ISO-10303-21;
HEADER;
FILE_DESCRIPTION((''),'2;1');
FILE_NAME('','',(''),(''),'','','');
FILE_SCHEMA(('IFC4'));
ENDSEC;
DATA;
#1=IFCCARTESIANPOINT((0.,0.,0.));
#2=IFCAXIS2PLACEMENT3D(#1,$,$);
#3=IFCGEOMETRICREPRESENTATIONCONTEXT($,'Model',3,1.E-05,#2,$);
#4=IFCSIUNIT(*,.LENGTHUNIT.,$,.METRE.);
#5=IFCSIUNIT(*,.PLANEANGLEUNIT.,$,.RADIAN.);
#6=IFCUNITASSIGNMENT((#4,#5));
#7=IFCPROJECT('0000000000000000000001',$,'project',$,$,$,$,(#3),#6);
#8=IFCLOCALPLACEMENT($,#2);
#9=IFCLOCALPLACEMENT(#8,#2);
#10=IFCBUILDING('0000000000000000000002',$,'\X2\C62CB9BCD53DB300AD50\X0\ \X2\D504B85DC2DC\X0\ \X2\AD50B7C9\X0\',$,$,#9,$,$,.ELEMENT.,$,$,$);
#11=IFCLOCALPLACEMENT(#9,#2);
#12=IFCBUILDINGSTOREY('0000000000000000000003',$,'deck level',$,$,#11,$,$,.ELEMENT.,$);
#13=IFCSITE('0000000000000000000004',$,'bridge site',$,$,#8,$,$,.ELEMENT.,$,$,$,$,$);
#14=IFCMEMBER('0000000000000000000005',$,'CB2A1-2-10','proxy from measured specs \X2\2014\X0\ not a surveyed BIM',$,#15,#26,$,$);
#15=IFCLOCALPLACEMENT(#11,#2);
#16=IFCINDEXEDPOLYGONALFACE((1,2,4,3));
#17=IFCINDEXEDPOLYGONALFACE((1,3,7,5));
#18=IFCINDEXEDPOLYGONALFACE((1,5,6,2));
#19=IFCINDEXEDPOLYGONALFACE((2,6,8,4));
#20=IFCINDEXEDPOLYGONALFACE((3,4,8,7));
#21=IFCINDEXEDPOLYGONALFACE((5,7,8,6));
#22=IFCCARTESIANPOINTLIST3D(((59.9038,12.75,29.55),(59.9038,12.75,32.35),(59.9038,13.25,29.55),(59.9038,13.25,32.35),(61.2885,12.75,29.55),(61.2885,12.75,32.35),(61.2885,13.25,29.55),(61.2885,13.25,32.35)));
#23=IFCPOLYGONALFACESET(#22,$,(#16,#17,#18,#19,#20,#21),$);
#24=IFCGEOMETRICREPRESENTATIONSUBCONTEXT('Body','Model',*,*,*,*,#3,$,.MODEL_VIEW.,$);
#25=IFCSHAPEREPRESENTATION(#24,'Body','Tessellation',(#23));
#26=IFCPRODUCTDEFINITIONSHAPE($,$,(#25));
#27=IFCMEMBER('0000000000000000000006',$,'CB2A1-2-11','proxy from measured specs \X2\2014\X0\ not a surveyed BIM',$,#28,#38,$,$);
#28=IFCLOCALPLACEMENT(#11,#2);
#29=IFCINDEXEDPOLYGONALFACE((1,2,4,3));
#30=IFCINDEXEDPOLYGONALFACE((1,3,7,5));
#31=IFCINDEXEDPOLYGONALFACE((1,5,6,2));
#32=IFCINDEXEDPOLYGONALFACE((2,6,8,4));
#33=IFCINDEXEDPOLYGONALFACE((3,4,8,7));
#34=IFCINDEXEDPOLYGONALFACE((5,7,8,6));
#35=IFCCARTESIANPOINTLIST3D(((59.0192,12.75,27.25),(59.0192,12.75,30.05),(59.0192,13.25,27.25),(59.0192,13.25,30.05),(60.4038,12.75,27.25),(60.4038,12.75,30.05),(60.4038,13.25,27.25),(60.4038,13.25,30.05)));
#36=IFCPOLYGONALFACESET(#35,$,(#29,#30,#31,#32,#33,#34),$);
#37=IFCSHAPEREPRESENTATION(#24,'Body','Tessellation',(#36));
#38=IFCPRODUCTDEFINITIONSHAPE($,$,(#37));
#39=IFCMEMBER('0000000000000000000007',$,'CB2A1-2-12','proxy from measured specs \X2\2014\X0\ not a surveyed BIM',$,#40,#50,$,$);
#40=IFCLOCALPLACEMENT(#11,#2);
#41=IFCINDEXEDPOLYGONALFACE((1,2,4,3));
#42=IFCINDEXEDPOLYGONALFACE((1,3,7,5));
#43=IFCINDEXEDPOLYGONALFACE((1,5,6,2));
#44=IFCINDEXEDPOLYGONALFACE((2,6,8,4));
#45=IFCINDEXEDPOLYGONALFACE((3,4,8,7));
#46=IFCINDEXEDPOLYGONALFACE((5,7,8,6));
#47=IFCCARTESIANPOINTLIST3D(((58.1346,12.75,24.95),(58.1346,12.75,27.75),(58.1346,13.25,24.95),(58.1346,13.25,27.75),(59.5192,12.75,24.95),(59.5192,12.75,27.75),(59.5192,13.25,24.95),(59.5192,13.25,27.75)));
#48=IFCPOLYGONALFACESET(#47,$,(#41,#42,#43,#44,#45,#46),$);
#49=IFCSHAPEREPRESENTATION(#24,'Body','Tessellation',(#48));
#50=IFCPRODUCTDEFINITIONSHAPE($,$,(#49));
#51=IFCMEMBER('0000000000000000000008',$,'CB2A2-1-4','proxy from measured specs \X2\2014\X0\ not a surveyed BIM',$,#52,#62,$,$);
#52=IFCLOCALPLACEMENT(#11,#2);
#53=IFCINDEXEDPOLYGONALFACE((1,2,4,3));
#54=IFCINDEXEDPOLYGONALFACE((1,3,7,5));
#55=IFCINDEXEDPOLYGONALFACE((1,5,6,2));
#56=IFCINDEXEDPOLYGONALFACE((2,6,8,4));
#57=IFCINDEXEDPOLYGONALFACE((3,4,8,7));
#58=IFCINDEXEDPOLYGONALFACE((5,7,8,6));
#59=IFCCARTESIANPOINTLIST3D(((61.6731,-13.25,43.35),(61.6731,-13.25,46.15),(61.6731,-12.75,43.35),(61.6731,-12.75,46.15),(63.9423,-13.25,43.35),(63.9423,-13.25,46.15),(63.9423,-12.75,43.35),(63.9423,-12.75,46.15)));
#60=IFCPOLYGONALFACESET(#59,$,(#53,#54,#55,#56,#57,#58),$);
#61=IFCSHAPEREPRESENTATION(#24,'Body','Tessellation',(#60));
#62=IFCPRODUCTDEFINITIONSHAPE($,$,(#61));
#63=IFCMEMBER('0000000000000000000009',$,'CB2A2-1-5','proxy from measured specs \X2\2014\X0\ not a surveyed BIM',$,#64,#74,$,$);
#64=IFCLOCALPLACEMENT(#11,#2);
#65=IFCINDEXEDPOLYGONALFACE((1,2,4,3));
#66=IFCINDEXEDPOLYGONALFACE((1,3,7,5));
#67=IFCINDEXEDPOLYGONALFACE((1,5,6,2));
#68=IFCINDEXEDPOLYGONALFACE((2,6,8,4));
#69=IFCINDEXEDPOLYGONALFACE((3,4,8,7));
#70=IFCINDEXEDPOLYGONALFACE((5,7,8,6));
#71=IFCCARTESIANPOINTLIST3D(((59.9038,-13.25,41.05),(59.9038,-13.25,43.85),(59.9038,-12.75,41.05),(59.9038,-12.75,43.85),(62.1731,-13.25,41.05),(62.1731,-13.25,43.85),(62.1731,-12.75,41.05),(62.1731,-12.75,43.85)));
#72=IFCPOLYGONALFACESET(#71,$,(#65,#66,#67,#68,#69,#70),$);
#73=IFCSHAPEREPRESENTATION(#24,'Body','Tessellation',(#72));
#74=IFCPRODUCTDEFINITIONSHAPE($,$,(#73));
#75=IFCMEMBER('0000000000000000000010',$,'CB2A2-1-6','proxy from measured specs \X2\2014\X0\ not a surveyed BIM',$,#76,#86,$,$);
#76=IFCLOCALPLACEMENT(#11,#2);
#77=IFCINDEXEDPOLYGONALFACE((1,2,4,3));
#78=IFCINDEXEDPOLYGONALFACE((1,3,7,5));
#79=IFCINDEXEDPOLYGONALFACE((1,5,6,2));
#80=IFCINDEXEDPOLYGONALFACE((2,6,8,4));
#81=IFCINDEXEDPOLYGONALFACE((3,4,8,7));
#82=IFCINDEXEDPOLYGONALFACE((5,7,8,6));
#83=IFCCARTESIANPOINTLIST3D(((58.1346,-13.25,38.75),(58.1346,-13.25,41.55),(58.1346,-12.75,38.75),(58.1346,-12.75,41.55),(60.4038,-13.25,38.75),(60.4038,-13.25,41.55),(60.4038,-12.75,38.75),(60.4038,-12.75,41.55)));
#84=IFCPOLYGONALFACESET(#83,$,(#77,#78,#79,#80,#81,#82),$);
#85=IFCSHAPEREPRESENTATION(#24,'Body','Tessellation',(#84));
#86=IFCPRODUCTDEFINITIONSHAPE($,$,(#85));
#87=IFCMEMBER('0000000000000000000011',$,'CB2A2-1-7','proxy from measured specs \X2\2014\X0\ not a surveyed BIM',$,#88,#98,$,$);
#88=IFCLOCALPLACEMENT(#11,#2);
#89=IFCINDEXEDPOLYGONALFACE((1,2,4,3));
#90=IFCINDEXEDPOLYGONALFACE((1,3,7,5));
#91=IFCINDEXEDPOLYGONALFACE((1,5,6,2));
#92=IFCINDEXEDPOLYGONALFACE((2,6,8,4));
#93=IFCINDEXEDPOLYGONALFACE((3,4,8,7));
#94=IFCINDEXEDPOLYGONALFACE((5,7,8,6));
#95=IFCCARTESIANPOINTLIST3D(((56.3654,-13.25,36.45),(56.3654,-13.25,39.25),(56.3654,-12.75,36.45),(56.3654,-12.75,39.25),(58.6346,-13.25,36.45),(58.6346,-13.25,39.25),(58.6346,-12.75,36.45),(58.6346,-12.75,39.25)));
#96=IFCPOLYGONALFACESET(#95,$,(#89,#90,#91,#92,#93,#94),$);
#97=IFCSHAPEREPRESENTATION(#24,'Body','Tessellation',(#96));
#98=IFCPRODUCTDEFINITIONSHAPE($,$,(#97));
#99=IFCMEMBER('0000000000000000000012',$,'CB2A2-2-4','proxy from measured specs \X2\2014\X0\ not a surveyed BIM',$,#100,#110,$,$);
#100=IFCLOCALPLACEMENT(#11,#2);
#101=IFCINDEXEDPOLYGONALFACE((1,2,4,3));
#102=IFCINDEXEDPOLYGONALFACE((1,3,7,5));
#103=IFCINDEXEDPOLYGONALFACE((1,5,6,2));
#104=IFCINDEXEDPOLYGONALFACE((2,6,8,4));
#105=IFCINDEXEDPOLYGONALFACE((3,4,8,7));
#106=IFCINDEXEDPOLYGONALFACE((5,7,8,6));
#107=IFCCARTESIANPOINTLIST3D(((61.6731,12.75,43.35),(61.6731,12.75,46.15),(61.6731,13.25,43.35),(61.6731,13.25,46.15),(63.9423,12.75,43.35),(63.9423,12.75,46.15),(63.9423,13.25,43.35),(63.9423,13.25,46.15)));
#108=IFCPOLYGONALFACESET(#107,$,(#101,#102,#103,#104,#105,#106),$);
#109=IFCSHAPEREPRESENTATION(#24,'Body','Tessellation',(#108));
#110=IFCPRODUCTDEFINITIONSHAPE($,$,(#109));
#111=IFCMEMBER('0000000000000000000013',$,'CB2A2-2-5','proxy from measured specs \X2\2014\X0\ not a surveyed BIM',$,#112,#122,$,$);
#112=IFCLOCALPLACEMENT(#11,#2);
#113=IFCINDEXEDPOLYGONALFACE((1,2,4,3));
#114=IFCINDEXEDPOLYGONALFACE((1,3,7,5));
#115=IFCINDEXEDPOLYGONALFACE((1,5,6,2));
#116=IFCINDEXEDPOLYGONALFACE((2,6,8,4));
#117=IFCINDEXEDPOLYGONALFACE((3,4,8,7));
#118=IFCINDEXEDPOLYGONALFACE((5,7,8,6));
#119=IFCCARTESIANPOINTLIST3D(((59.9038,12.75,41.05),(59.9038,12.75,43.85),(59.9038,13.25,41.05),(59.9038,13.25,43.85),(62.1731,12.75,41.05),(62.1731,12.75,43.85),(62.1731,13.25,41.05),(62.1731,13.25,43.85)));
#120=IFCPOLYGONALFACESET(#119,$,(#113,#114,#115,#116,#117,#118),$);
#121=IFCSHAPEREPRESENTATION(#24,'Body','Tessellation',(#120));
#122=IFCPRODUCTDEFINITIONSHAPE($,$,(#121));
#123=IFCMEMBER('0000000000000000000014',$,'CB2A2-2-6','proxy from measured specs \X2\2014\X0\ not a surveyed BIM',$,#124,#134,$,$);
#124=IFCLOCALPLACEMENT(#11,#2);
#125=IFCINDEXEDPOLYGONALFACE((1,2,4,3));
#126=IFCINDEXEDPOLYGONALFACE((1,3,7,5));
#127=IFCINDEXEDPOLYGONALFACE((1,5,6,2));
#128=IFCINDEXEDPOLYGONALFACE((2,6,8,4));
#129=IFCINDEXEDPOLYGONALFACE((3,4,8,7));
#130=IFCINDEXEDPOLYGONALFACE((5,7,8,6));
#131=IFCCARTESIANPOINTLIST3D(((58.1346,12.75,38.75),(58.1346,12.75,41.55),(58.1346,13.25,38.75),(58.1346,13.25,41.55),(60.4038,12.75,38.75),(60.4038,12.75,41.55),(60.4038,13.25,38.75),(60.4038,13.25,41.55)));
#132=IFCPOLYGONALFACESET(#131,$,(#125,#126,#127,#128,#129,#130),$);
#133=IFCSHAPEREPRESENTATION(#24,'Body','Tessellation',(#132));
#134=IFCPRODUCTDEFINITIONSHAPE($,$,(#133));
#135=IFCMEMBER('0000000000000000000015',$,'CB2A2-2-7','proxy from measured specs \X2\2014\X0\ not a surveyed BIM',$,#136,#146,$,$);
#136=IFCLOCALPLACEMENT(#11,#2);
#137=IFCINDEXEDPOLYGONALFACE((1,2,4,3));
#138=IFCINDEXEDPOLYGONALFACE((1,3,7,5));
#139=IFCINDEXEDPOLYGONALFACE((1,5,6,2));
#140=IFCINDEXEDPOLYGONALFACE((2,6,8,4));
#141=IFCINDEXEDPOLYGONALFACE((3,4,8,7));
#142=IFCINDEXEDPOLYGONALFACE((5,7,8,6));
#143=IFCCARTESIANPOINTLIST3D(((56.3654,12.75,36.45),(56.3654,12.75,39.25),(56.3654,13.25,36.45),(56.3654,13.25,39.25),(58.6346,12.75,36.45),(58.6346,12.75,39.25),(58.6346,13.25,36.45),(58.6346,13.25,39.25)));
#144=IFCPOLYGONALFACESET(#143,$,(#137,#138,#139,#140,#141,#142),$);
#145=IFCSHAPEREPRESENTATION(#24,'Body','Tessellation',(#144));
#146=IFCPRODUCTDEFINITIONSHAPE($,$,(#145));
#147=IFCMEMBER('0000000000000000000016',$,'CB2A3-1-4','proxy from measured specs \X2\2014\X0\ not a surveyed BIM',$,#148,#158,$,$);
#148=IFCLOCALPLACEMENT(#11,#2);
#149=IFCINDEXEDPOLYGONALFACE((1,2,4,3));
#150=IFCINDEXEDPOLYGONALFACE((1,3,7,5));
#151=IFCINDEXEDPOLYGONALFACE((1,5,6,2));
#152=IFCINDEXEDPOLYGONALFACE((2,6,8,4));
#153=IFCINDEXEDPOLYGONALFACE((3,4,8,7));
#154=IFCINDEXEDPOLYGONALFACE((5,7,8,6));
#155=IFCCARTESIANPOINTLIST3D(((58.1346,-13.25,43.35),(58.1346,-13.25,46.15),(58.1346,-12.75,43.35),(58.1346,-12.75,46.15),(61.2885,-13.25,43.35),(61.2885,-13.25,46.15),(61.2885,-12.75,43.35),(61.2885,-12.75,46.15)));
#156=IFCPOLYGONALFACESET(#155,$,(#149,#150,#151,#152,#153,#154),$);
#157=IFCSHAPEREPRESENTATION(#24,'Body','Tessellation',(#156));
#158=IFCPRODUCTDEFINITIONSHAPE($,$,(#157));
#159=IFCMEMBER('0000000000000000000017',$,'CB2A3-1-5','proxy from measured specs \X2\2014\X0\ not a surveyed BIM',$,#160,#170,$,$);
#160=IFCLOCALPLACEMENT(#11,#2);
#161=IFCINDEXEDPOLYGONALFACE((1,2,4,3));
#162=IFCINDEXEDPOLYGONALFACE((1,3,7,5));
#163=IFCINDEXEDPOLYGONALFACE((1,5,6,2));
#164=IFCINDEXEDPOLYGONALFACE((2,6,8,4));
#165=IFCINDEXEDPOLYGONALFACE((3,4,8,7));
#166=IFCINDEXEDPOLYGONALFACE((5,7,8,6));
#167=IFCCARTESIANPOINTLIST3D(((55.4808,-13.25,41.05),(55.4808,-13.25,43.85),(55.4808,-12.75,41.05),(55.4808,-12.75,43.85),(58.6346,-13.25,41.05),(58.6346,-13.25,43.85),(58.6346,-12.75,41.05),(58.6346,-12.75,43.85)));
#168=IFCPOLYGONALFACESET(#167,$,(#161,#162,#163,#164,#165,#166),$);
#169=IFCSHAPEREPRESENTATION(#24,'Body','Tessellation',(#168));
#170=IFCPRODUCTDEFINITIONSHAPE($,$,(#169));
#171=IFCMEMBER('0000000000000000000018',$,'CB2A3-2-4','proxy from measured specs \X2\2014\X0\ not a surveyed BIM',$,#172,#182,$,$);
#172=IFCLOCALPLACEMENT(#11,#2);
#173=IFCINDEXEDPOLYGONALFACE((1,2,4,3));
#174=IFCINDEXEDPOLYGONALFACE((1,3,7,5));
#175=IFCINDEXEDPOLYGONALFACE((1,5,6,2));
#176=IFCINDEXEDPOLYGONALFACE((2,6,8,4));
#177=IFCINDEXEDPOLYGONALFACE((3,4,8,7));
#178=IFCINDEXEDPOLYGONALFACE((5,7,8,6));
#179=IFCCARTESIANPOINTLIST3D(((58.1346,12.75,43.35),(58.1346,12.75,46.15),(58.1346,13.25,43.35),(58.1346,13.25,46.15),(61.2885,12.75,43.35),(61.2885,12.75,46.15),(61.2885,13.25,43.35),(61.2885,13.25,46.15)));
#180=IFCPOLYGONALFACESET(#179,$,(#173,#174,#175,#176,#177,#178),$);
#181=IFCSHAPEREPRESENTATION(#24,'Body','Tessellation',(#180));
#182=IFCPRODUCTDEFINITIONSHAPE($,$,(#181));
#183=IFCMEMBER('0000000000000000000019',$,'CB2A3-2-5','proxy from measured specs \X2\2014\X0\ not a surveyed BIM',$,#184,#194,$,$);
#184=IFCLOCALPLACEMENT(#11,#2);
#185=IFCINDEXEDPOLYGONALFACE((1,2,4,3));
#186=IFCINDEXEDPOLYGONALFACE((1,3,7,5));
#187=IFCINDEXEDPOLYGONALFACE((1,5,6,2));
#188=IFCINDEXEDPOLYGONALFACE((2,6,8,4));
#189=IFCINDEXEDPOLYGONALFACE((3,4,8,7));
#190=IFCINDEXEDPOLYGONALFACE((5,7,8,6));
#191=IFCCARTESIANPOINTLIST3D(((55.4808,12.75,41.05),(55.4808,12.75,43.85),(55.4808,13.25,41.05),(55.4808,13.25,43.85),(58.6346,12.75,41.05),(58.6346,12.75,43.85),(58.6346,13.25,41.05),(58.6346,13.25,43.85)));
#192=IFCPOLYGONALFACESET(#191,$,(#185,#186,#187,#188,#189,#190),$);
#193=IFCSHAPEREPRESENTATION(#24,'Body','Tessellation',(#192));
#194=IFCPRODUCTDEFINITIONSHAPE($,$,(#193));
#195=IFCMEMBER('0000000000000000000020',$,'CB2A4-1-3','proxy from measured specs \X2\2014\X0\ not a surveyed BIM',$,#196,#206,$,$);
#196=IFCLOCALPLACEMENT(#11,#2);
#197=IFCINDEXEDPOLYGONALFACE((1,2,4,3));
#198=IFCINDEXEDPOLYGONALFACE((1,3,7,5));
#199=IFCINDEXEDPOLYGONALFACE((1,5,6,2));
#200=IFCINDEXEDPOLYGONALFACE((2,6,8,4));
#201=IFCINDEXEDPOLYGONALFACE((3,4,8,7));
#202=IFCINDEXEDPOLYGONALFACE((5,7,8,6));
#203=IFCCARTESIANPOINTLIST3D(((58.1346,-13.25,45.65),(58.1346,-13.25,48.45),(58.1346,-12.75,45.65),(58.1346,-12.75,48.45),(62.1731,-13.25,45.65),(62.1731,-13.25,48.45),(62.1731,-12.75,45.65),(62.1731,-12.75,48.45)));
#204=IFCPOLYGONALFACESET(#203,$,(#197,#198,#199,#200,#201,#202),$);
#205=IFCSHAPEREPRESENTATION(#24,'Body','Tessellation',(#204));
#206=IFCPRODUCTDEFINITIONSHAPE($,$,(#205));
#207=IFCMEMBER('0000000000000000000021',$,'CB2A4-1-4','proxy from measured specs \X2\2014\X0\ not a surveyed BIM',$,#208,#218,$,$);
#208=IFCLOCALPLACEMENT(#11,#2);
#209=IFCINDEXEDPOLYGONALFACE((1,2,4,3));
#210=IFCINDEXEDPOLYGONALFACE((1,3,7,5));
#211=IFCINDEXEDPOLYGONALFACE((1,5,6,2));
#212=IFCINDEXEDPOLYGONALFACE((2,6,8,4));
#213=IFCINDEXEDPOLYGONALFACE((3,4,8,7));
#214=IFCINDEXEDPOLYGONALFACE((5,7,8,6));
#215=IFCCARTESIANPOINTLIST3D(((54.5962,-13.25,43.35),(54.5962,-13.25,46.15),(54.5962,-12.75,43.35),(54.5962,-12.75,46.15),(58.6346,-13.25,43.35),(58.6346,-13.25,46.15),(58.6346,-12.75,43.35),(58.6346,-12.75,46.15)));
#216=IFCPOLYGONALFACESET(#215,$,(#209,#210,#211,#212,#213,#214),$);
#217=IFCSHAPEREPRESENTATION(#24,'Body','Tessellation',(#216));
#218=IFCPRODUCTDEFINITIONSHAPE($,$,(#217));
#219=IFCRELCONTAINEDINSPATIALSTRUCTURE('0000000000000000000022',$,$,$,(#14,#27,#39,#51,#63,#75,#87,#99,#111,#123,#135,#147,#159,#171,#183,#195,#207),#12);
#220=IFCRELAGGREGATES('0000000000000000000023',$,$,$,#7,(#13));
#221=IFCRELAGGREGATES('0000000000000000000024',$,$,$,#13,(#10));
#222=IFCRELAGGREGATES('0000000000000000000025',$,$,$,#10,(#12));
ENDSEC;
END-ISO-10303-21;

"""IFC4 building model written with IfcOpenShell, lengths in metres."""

from ifc_helpers import new_model, si_unit, frame, origin, origin_2d, place, context, subcontext, project, spatial, rectangle, extrude, element, save


model = new_model("IFC4")

# Units and contexts
model_context = context("Model", 3, precision=1e-05, world=origin())
body_context = subcontext(model_context, "Body", "Model", "MODEL_VIEW")
ifc_project = project(units=[si_unit("LENGTHUNIT", "METRE"), si_unit("PLANEANGLEUNIT", "RADIAN")], contexts=[model_context])

# Site, building, storey
site_placement = place(None, origin())
site = spatial("IfcSite", under=ifc_project, at=site_placement, Name="bridge site", CompositionType="ELEMENT")
building_placement = place(site_placement, origin())
building = spatial("IfcBuilding", under=site, at=building_placement, Name="올림픽대교 프록시 교량", CompositionType="ELEMENT")
storey_placement = place(building_placement, origin())
storey = spatial("IfcBuildingStorey", under=building, at=storey_placement, Name="deck level", CompositionType="ELEMENT")

# Members
member_1_placement = place(storey_placement, frame((60.5962, 13.0, 29.55)))
element("IfcMember", 1, at=member_1_placement, inside=storey, Name="CB2A1-2-10", Description="proxy from measured specs — not a surveyed BIM", context=body_context, shape_type="SweptSolid", body=[
    extrude(rectangle(XDim=1.3846, YDim=0.5, at=origin_2d()), origin(), (0.0, 0.0, 1.0), 2.8),
])
member_2_placement = place(storey_placement, frame((59.7115, 13.0, 27.25)))
element("IfcMember", 2, at=member_2_placement, inside=storey, Name="CB2A1-2-11", Description="proxy from measured specs — not a surveyed BIM", context=body_context, shape_type="SweptSolid", body=[
    extrude(rectangle(XDim=1.3846, YDim=0.5, at=origin_2d()), origin(), (0.0, 0.0, 1.0), 2.8),
])
member_3_placement = place(storey_placement, frame((58.8269, 13.0, 24.95)))
element("IfcMember", 3, at=member_3_placement, inside=storey, Name="CB2A1-2-12", Description="proxy from measured specs — not a surveyed BIM", context=body_context, shape_type="SweptSolid", body=[
    extrude(rectangle(XDim=1.3846, YDim=0.5, at=origin_2d()), origin(), (0.0, 0.0, 1.0), 2.8),
])
member_4_placement = place(storey_placement, frame((62.8077, -13.0, 43.35)))
element("IfcMember", 4, at=member_4_placement, inside=storey, Name="CB2A2-1-4", Description="proxy from measured specs — not a surveyed BIM", context=body_context, shape_type="SweptSolid", body=[
    extrude(rectangle(XDim=2.2692, YDim=0.5, at=origin_2d()), origin(), (0.0, 0.0, 1.0), 2.8),
])
member_5_placement = place(storey_placement, frame((61.0385, -13.0, 41.05)))
element("IfcMember", 5, at=member_5_placement, inside=storey, Name="CB2A2-1-5", Description="proxy from measured specs — not a surveyed BIM", context=body_context, shape_type="SweptSolid", body=[
    extrude(rectangle(XDim=2.2692, YDim=0.5, at=origin_2d()), origin(), (0.0, 0.0, 1.0), 2.8),
])
for number, where, name in (
    (6, (59.2692, -13.0, 38.75), "CB2A2-1-6"),
    (7, (57.5, -13.0, 36.45), "CB2A2-1-7"),
):
    element("IfcMember", number, at=place(storey_placement, frame(where)), inside=storey, Name=name, Description="proxy from measured specs — not a surveyed BIM", context=body_context, shape_type="SweptSolid", body=[
        extrude(rectangle(XDim=2.2692, YDim=0.5, at=origin_2d()), origin(), (0.0, 0.0, 1.0), 2.8),
    ])
member_6_placement = place(storey_placement, frame((62.8077, 13.0, 43.35)))
element("IfcMember", 8, at=member_6_placement, inside=storey, Name="CB2A2-2-4", Description="proxy from measured specs — not a surveyed BIM", context=body_context, shape_type="SweptSolid", body=[
    extrude(rectangle(XDim=2.2692, YDim=0.5, at=origin_2d()), origin(), (0.0, 0.0, 1.0), 2.8),
])
member_7_placement = place(storey_placement, frame((61.0385, 13.0, 41.05)))
element("IfcMember", 9, at=member_7_placement, inside=storey, Name="CB2A2-2-5", Description="proxy from measured specs — not a surveyed BIM", context=body_context, shape_type="SweptSolid", body=[
    extrude(rectangle(XDim=2.2692, YDim=0.5, at=origin_2d()), origin(), (0.0, 0.0, 1.0), 2.8),
])
for number, where, name in (
    (10, (59.2692, 13.0, 38.75), "CB2A2-2-6"),
    (11, (57.5, 13.0, 36.45), "CB2A2-2-7"),
):
    element("IfcMember", number, at=place(storey_placement, frame(where)), inside=storey, Name=name, Description="proxy from measured specs — not a surveyed BIM", context=body_context, shape_type="SweptSolid", body=[
        extrude(rectangle(XDim=2.2692, YDim=0.5, at=origin_2d()), origin(), (0.0, 0.0, 1.0), 2.8),
    ])
member_8_placement = place(storey_placement, frame((59.7115, -13.0, 43.35)))
element("IfcMember", 12, at=member_8_placement, inside=storey, Name="CB2A3-1-4", Description="proxy from measured specs — not a surveyed BIM", context=body_context, shape_type="SweptSolid", body=[
    extrude(rectangle(XDim=3.1538, YDim=0.5, at=origin_2d()), origin(), (0.0, 0.0, 1.0), 2.8),
])
member_9_placement = place(storey_placement, frame((57.0577, -13.0, 41.05)))
element("IfcMember", 13, at=member_9_placement, inside=storey, Name="CB2A3-1-5", Description="proxy from measured specs — not a surveyed BIM", context=body_context, shape_type="SweptSolid", body=[
    extrude(rectangle(XDim=3.1538, YDim=0.5, at=origin_2d()), origin(), (0.0, 0.0, 1.0), 2.8),
])
member_10_placement = place(storey_placement, frame((59.7115, 13.0, 43.35)))
element("IfcMember", 14, at=member_10_placement, inside=storey, Name="CB2A3-2-4", Description="proxy from measured specs — not a surveyed BIM", context=body_context, shape_type="SweptSolid", body=[
    extrude(rectangle(XDim=3.1538, YDim=0.5, at=origin_2d()), origin(), (0.0, 0.0, 1.0), 2.8),
])
member_11_placement = place(storey_placement, frame((57.0577, 13.0, 41.05)))
element("IfcMember", 15, at=member_11_placement, inside=storey, Name="CB2A3-2-5", Description="proxy from measured specs — not a surveyed BIM", context=body_context, shape_type="SweptSolid", body=[
    extrude(rectangle(XDim=3.1538, YDim=0.5, at=origin_2d()), origin(), (0.0, 0.0, 1.0), 2.8),
])
member_12_placement = place(storey_placement, frame((60.1538, -13.0, 45.65)))
element("IfcMember", 16, at=member_12_placement, inside=storey, Name="CB2A4-1-3", Description="proxy from measured specs — not a surveyed BIM", context=body_context, shape_type="SweptSolid", body=[
    extrude(rectangle(XDim=4.0385, YDim=0.5, at=origin_2d()), origin(), (0.0, 0.0, 1.0), 2.8),
])
member_13_placement = place(storey_placement, frame((56.6154, -13.0, 43.35)))
element("IfcMember", 17, at=member_13_placement, inside=storey, Name="CB2A4-1-4", Description="proxy from measured specs — not a surveyed BIM", context=body_context, shape_type="SweptSolid", body=[
    extrude(rectangle(XDim=4.0385, YDim=0.5, at=origin_2d()), origin(), (0.0, 0.0, 1.0), 2.8),
])

save(model, "model.ifc")
